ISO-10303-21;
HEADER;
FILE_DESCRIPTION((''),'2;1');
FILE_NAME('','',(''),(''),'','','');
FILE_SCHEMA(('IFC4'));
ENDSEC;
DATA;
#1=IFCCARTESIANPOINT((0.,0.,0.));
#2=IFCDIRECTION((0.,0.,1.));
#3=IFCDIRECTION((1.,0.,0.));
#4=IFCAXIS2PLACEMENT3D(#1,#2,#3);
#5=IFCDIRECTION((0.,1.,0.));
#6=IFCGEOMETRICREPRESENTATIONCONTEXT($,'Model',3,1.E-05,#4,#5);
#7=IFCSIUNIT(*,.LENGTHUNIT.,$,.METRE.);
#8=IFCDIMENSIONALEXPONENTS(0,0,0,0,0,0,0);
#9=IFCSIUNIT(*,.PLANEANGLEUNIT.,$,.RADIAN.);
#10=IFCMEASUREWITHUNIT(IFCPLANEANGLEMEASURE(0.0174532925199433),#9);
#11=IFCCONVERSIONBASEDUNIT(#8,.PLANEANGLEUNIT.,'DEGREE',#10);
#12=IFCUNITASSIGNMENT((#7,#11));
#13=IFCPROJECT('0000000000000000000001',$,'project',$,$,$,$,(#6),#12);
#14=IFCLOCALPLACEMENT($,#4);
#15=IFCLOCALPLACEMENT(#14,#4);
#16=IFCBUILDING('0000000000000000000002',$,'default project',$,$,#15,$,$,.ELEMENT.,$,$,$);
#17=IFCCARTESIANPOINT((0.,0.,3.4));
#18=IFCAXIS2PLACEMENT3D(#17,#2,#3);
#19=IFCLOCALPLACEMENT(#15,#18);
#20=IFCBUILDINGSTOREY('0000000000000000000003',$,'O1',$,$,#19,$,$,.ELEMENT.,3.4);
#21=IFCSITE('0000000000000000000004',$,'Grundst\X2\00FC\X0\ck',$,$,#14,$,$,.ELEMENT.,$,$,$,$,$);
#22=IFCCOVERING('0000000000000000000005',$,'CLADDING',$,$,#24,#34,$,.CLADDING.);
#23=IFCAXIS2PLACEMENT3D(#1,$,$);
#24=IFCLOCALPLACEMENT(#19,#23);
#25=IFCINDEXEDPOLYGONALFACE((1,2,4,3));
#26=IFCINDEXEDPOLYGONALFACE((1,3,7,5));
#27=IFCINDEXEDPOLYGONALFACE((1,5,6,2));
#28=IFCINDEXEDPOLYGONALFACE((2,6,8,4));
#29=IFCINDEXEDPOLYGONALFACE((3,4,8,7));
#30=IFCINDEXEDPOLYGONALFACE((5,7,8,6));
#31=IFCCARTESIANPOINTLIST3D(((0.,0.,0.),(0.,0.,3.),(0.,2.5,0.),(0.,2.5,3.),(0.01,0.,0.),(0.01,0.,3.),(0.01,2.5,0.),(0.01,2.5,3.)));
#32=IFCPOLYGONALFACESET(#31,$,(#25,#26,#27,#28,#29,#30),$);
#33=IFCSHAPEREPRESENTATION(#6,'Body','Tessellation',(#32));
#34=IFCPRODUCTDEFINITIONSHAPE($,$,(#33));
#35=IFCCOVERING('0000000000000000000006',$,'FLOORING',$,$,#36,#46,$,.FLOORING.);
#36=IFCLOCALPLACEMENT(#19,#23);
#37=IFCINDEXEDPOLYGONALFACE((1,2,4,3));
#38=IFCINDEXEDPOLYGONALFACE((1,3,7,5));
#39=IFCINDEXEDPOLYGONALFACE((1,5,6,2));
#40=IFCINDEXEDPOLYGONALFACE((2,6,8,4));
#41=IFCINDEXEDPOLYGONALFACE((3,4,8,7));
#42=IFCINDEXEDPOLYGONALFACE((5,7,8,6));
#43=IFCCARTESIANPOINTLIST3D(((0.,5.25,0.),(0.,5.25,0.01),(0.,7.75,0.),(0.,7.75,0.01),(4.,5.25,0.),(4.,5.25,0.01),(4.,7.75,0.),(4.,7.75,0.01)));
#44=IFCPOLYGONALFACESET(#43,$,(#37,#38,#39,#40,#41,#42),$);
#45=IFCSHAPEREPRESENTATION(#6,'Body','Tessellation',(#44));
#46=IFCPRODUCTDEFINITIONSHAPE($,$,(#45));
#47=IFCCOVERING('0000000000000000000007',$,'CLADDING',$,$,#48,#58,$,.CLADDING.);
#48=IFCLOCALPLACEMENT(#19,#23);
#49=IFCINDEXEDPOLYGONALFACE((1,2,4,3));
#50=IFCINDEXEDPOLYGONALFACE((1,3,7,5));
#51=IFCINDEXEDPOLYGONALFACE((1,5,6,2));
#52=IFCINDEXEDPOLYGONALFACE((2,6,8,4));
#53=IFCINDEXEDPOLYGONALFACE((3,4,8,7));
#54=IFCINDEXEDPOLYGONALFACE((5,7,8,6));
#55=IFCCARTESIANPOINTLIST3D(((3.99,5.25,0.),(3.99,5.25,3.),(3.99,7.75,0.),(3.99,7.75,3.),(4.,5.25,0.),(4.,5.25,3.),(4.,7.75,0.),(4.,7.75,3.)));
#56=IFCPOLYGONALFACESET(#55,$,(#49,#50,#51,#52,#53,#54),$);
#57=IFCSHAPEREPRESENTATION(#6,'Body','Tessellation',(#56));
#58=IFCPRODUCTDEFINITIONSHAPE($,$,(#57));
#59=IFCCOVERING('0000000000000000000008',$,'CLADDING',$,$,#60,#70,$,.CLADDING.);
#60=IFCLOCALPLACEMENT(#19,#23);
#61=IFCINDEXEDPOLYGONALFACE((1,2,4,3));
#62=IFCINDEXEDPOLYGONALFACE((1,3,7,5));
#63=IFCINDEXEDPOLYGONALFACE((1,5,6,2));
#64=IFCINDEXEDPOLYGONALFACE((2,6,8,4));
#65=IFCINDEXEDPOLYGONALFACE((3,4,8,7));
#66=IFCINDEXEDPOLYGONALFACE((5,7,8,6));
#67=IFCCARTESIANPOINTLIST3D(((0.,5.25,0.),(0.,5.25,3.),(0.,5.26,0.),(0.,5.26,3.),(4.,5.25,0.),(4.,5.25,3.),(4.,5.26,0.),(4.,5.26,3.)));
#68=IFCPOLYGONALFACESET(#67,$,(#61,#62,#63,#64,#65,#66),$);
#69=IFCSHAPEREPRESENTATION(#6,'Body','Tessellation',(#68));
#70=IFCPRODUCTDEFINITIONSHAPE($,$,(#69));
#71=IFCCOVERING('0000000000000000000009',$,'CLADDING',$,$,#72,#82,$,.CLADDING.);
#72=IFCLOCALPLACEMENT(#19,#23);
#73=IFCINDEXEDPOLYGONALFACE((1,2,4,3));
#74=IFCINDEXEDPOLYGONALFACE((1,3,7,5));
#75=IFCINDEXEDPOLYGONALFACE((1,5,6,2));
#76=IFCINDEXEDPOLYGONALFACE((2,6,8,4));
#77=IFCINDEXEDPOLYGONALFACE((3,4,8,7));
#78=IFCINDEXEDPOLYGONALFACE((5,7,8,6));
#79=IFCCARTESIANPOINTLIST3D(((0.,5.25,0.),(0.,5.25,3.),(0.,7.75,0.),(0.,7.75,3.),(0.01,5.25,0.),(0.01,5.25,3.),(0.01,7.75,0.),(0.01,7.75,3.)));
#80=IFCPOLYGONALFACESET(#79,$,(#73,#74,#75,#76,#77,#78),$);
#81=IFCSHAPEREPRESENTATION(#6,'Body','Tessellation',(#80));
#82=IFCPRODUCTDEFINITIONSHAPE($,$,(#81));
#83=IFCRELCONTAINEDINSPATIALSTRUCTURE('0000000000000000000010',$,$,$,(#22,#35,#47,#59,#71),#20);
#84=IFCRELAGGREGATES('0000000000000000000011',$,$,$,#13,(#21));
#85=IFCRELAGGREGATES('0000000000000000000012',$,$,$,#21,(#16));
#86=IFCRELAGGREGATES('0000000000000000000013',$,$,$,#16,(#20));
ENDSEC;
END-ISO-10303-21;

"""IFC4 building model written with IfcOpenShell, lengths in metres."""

from ifc_helpers import new_model, entity, si_unit, converted_unit, direction, frame, origin_with_axes, place, context, project, spatial, polyline, outline, extrude, element, save


model = new_model("IFC4")

# Units and contexts
model_context = context("Model", 3, precision=1e-05, world=origin_with_axes(), true_north=direction((0.0, 1.0, 0.0)))
ifc_project = project(units=[si_unit("LENGTHUNIT", "METRE"), converted_unit("PLANEANGLEUNIT", "DEGREE", entity("IfcPlaneAngleMeasure", 0.0174532925199433), si_unit("PLANEANGLEUNIT", "RADIAN"), dimensions=[0, 0, 0, 0, 0, 0, 0])], contexts=[model_context])

# Site, building, storey
site_placement = place(None, origin_with_axes())
site = spatial("IfcSite", under=ifc_project, at=site_placement, Name="Grundstück", CompositionType="ELEMENT")
building_placement = place(site_placement, origin_with_axes())
building = spatial("IfcBuilding", under=site, at=building_placement, Name="default project", CompositionType="ELEMENT")
placement_1 = place(building_placement, frame((0.0, 0.0, 3.4), z_axis=(0.0, 0.0, 1.0), x_axis=(1.0, 0.0, 0.0)))
storey = spatial("IfcBuildingStorey", under=building, at=placement_1, Name="O1", CompositionType="ELEMENT", Elevation=3.4)

# Coverings
element("IfcCovering", 1, at=placement_1, inside=storey, Name="CLADDING", PredefinedType="CLADDING", context=model_context, shape_type="SweptSolid", body=[
    extrude(outline(polyline([(0.01, 0.0), (0.01, 2.5), (0.0, 2.5), (0.0, 0.0), (0.01, 0.0)])), origin_with_axes(), (0.0, 0.0, 1.0), 3.0),
])
element("IfcCovering", 2, at=placement_1, inside=storey, Name="FLOORING", PredefinedType="FLOORING", context=model_context, shape_type="SweptSolid", body=[
    extrude(outline(polyline([(4.0, 7.75), (0.0, 7.75), (0.0, 5.25), (4.0, 5.25), (4.0, 7.75)])), origin_with_axes(), (0.0, 0.0, 1.0), 0.01),
])
element("IfcCovering", 3, at=placement_1, inside=storey, Name="CLADDING", PredefinedType="CLADDING", context=model_context, shape_type="SweptSolid", body=[
    extrude(outline(polyline([(3.99, 7.75), (3.99, 5.25), (4.0, 5.25), (4.0, 7.75), (3.99, 7.75)])), origin_with_axes(), (0.0, 0.0, 1.0), 3.0),
])
element("IfcCovering", 4, at=placement_1, inside=storey, Name="CLADDING", PredefinedType="CLADDING", context=model_context, shape_type="SweptSolid", body=[
    extrude(outline(polyline([(4.0, 5.26), (0.0, 5.26), (0.0, 5.25), (4.0, 5.25), (4.0, 5.26)])), origin_with_axes(), (0.0, 0.0, 1.0), 3.0),
])
element("IfcCovering", 5, at=placement_1, inside=storey, Name="CLADDING", PredefinedType="CLADDING", context=model_context, shape_type="SweptSolid", body=[
    extrude(outline(polyline([(0.01, 5.25), (0.01, 7.75), (0.0, 7.75), (0.0, 5.25), (0.01, 5.25)])), origin_with_axes(), (0.0, 0.0, 1.0), 3.0),
])

save(model, "model.ifc")
